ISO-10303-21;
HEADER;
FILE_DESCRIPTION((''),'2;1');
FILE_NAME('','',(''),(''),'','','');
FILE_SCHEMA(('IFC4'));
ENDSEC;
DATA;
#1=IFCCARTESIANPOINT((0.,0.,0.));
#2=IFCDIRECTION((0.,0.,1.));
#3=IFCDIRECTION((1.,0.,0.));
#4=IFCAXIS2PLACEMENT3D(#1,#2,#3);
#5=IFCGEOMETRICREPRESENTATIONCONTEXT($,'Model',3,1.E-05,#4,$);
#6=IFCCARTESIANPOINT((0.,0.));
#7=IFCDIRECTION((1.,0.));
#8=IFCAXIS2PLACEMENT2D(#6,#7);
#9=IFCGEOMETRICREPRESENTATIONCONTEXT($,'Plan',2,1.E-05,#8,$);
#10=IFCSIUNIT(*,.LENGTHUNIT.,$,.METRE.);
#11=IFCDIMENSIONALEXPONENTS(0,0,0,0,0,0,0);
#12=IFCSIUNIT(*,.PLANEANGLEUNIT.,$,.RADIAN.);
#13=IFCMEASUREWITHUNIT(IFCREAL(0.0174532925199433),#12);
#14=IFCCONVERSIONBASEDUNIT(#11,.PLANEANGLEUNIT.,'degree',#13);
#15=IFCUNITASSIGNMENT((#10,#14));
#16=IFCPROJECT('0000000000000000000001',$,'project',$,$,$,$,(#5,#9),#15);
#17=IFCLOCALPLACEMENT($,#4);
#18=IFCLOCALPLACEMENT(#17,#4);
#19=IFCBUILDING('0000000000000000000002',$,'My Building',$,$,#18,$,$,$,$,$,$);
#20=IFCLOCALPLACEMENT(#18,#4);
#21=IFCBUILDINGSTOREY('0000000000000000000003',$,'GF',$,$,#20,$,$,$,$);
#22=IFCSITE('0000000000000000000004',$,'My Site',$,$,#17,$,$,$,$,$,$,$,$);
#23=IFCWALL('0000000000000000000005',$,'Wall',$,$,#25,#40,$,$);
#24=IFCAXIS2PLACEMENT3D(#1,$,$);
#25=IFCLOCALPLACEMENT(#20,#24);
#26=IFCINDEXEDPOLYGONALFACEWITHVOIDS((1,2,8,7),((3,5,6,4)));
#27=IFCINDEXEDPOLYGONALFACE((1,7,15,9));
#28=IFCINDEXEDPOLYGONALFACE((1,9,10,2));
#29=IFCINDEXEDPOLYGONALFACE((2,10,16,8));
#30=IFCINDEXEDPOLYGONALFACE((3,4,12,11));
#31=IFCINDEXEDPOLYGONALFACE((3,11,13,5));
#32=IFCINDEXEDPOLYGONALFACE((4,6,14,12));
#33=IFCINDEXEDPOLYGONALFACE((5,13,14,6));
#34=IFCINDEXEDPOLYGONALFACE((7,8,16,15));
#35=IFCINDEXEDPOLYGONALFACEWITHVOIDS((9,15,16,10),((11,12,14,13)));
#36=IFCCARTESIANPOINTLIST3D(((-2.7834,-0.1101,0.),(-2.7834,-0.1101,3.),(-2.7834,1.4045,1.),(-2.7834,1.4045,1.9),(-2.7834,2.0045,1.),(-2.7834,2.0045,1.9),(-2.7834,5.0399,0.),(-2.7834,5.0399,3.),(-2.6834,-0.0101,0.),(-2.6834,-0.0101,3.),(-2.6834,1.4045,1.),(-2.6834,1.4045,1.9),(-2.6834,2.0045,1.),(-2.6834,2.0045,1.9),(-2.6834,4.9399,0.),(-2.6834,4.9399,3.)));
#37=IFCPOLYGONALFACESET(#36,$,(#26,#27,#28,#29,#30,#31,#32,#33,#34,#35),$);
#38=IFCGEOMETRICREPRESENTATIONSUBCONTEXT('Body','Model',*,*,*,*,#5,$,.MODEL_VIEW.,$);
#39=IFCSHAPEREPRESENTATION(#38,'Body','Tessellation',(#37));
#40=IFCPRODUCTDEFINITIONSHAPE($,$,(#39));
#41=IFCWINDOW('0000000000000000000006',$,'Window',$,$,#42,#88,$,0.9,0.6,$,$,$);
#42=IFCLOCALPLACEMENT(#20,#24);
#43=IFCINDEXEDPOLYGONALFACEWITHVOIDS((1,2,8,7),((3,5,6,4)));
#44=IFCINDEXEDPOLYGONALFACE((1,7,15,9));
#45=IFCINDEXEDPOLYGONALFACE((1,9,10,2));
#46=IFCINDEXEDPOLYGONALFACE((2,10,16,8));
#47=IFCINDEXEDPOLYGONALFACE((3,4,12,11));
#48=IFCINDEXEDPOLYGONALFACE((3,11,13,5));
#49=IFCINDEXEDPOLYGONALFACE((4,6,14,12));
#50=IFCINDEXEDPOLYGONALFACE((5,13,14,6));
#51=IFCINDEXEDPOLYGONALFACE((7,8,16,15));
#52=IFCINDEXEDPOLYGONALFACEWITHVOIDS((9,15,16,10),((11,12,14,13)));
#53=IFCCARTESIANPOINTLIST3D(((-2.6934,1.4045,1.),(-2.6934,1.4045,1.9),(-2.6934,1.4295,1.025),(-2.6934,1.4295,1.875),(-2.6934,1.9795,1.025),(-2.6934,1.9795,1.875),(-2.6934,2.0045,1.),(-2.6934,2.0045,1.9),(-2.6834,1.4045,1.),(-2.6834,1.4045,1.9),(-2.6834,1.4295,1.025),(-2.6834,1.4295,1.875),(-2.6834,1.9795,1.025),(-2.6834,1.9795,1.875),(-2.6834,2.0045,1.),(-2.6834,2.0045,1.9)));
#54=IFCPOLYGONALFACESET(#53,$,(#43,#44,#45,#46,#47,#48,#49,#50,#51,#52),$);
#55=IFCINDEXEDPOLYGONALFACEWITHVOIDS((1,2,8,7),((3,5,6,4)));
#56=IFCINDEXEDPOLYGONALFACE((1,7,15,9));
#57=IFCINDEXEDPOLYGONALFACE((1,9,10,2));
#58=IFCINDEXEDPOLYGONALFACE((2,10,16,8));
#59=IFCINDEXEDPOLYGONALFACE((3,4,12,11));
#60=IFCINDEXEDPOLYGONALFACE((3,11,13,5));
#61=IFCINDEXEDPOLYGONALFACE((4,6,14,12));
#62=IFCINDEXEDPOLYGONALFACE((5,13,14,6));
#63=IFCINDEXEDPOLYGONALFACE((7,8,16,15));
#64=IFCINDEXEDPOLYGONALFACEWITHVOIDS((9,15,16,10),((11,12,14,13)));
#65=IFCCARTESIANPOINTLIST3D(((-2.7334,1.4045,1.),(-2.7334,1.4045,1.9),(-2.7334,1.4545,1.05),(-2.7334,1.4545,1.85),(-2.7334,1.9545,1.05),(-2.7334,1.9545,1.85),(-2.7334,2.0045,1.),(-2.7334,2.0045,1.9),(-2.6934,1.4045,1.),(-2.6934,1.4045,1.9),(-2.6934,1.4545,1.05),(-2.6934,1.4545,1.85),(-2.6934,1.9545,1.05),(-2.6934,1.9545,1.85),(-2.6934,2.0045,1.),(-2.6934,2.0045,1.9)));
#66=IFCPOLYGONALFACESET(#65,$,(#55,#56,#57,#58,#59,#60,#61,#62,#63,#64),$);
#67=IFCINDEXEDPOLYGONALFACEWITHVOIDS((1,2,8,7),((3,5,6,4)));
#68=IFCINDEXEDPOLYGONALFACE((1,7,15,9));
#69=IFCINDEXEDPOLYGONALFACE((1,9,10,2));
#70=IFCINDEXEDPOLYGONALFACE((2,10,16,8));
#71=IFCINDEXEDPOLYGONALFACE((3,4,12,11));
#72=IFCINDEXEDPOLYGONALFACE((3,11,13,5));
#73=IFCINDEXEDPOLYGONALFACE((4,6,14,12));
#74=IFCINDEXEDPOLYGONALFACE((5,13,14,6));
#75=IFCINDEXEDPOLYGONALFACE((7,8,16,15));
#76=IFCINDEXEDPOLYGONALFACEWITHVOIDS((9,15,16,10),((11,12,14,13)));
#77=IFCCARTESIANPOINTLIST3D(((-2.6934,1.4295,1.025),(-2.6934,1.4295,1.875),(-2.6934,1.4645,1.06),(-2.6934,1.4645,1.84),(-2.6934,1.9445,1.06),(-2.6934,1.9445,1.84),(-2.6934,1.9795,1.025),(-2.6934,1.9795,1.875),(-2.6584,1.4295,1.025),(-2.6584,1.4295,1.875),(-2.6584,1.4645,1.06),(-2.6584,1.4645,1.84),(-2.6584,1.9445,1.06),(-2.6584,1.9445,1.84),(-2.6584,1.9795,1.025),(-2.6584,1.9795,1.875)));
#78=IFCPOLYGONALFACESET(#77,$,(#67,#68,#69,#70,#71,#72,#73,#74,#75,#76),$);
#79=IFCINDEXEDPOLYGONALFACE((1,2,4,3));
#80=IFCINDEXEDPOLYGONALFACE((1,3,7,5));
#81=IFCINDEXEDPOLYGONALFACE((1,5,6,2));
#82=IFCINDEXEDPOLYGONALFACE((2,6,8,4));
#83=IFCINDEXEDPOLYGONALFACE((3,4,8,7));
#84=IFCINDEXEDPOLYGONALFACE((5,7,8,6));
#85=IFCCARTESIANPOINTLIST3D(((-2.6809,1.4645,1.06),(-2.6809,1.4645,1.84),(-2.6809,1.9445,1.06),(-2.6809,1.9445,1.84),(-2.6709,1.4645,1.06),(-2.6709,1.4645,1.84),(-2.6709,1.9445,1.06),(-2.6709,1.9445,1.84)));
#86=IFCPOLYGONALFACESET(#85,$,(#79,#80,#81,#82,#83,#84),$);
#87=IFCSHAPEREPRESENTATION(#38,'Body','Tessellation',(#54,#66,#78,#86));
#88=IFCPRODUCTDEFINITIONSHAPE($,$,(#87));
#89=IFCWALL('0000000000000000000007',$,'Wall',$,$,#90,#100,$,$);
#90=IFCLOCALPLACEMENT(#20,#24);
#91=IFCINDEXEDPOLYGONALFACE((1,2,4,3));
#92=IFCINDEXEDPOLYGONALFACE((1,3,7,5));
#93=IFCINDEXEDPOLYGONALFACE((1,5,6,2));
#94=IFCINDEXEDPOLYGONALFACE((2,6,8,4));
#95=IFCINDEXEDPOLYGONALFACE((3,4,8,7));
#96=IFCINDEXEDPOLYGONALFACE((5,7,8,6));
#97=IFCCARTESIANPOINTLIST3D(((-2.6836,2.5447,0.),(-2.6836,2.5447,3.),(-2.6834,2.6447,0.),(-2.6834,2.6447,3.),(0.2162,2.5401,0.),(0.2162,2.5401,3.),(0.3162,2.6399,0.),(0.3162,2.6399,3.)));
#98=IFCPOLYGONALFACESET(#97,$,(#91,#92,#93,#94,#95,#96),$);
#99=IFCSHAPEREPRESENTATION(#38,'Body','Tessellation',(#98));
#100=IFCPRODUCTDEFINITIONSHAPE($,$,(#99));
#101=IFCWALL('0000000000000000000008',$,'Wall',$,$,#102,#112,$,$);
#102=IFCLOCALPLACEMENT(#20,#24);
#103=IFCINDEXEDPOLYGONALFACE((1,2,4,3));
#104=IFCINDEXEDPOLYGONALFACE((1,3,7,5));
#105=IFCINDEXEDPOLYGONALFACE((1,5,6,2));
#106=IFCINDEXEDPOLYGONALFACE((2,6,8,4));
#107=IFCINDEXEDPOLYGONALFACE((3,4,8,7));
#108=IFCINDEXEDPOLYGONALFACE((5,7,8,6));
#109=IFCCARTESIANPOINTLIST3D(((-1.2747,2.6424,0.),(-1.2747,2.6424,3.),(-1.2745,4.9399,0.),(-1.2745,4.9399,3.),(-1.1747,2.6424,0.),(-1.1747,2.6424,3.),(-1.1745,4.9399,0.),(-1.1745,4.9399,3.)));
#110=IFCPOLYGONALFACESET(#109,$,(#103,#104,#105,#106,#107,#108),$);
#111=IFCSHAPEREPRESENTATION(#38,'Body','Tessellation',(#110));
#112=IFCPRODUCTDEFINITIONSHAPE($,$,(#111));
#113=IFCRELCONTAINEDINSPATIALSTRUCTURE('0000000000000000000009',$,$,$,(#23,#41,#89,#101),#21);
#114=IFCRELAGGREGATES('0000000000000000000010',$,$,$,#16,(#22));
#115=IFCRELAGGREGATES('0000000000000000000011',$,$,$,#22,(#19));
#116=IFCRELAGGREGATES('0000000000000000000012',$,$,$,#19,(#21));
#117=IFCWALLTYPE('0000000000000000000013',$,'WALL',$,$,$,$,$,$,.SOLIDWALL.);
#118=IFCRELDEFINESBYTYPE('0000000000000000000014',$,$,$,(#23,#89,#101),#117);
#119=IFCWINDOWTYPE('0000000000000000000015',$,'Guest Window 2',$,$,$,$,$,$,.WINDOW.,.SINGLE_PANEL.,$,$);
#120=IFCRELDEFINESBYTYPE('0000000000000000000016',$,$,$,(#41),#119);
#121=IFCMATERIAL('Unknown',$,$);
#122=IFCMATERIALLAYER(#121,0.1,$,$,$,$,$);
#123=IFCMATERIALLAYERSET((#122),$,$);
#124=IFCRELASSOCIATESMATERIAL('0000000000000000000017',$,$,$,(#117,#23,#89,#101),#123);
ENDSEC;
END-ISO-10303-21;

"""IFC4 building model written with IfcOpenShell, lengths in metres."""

from ifc_helpers import new_model, entity, si_unit, converted_unit, frame, origin_with_axes, origin_2d_with_axis, place, context, subcontext, project, spatial, line, indexed_curve, outline, extrude, shape, source, transform, mapped, material, layer, layer_set, layer_usage, type_object, type_shapes, element, fill, save


model = new_model("IFC4")

# Units and contexts
model_context = context("Model", 3, precision=1e-05, world=origin_with_axes())
plan_context = context("Plan", 2, precision=1e-05, world=origin_2d_with_axis())
body_context_1 = subcontext(model_context, "Body", "Model", "MODEL_VIEW")
body_context_2 = subcontext(plan_context, "Body", "Plan", "PLAN_VIEW")
ifc_project = project(units=[si_unit("LENGTHUNIT", "METRE"), converted_unit("PLANEANGLEUNIT", "degree", entity("IfcReal", 0.0174532925199433), si_unit("PLANEANGLEUNIT", "RADIAN"), dimensions=[0, 0, 0, 0, 0, 0, 0])], contexts=[model_context, plan_context])

# Site, building, storey
site_placement = place(None, origin_with_axes())
site = spatial("IfcSite", under=ifc_project, at=site_placement, Name="My Site")
building_placement = place(site_placement, origin_with_axes())
building = spatial("IfcBuilding", under=site, at=building_placement, Name="My Building")
storey_placement = place(building_placement, origin_with_axes())
storey = spatial("IfcBuildingStorey", under=building, at=storey_placement, Name="GF")

# Shared definitions
ifc_material = material(Name="Unknown")

# Shared definitions
ifc_layer = layer(ifc_material, 0.1)
ifc_layer_set = layer_set([ifc_layer])
wall_type = type_object("IfcWallType", Name="WALL", PredefinedType="SOLIDWALL", material=ifc_layer_set)

# Wall, opening, window
ifc_layer_usage_1 = layer_usage(ifc_layer_set, "AXIS2", "POSITIVE", 0.0)
wall_1_placement = place(storey_placement, frame((-2.7834, 5.0399, 0.0), z_axis=(0.0, 0.0, 1.0), x_axis=(0.0, -1.0, 0.0)))
wall_1 = element("IfcWall", 1, at=wall_1_placement, inside=storey, type_object=wall_type, material=ifc_layer_usage_1, Name="Wall", context=body_context_1, shape_type="SweptSolid", body=[
    extrude(outline(indexed_curve([(0.0, 0.0), (0.1, 0.1), (5.05, 0.1), (5.15, 0.0)], segments=[line(1, 2, 3, 4, 1)])), origin_with_axes(), (0.0, 0.0, 1.0), 3.0),
])
shared_shape_1 = source(origin_with_axes(), body_context_1, "Body", "SweptSolid", [
    extrude(outline(indexed_curve([(0.0, 0.0), (0.6, 0.0), (0.6, 0.9), (0.0, 0.9)], segments=[line(1, 2, 3, 4, 1)])), frame((0.0, -0.6, 0.0), z_axis=(0.0, -1.0, 0.0), x_axis=(1.0, 0.0, 0.0)), (0.0, 0.0, -1.0), 1.2),
])
opening_1_placement = place(wall_1_placement, frame((3.0354, 0.0, 1.0), z_axis=(0.0, 0.0, 1.0), x_axis=(1.0, 0.0, 0.0)))
opening_1 = element("IfcOpeningElement", 2, at=opening_1_placement, cuts=wall_1, PredefinedType="OPENING", context=body_context_1, shape_type="MappedRepresentation", body=[
    mapped(shared_shape_1, transform((0.0, 0.0, 0.0), x_axis=(1.0, 0.0, 0.0), y_axis=(0.0, 1.0, 0.0), z_axis=(0.0, 0.0, 1.0), scale=1.0)),
])
window_type_1 = type_object("IfcWindowType", Name="Guest Window 2", PartitioningType="SINGLE_PANEL", PredefinedType="WINDOW")
shared_shape_2 = source(origin_with_axes(), body_context_1, "Body", "SweptSolid", [
    extrude(outline(indexed_curve([(0.0, 0.0), (0.6, 0.0), (0.6, 0.9), (0.0, 0.9)], segments=[line(1, 2, 3, 4, 1)]), holes=[indexed_curve([(0.025, 0.025), (0.575, 0.025), (0.575, 0.875), (0.025, 0.875)], segments=[line(1, 2, 3, 4, 1)])]), frame((0.0, 0.09, 0.0), z_axis=(0.0, -1.0, 0.0), x_axis=(1.0, 0.0, 0.0)), (0.0, 0.0, -1.0), 0.01),
    extrude(outline(indexed_curve([(0.0, 0.0), (0.6, 0.0), (0.6, 0.9), (0.0, 0.9)], segments=[line(1, 2, 3, 4, 1)]), holes=[indexed_curve([(0.05, 0.05), (0.55, 0.05), (0.55, 0.85), (0.05, 0.85)], segments=[line(1, 2, 3, 4, 1)])]), frame((0.0, 0.05, 0.0), z_axis=(0.0, -1.0, 0.0), x_axis=(1.0, 0.0, 0.0)), (0.0, 0.0, -1.0), 0.04),
    extrude(outline(indexed_curve([(0.0, 0.0), (0.55, 0.0), (0.55, 0.85), (0.0, 0.85)], segments=[line(1, 2, 3, 4, 1)]), holes=[indexed_curve([(0.035, 0.035), (0.515, 0.035), (0.515, 0.815), (0.035, 0.815)], segments=[line(1, 2, 3, 4, 1)])]), frame((0.025, 0.09, 0.025), z_axis=(0.0, -1.0, 0.0), x_axis=(1.0, 0.0, 0.0)), (0.0, 0.0, -1.0), 0.035),
    extrude(outline(indexed_curve([(0.035, 0.035), (0.515, 0.035), (0.515, 0.815), (0.035, 0.815)], segments=[line(1, 2, 3, 4, 1)])), frame((0.025, 0.1025, 0.025), z_axis=(0.0, -1.0, 0.0), x_axis=(1.0, 0.0, 0.0)), (0.0, 0.0, -1.0), 0.01),
])
shared_shape_3 = source(origin_with_axes(), body_context_2, "Body", "Curve2D", [
    entity("IfcIndexedPolyCurve", entity("IfcCartesianPointList2D", [[0.05, 0.05], [0.55, 0.05]])),
    entity("IfcIndexedPolyCurve", entity("IfcCartesianPointList2D", [[0.0, 0.1], [0.025, 0.1], [0.025, 0.09], [0.05, 0.09], [0.05, 0.05], [0.0, 0.05]]), [entity("IfcLineIndex", [1, 2, 3, 4, 5, 6, 1])]),
    entity("IfcIndexedPolyCurve", entity("IfcCartesianPointList2D", [[0.6, 0.1], [0.575, 0.1], [0.575, 0.09], [0.55, 0.09], [0.55, 0.05], [0.6, 0.05]]), [entity("IfcLineIndex", [1, 2, 3, 4, 5, 6, 1])]),
    entity("IfcIndexedPolyCurve", entity("IfcCartesianPointList2D", [[0.025, 0.09], [0.06, 0.09], [0.06, 0.125], [0.025, 0.125]]), [entity("IfcLineIndex", [1, 2, 3, 4, 1])]),
    entity("IfcIndexedPolyCurve", entity("IfcCartesianPointList2D", [[0.575, 0.09], [0.54, 0.09], [0.54, 0.125], [0.575, 0.125]]), [entity("IfcLineIndex", [1, 2, 3, 4, 1])]),
    entity("IfcIndexedPolyCurve", entity("IfcCartesianPointList2D", [[0.06, 0.09], [0.54, 0.09]])),
    entity("IfcIndexedPolyCurve", entity("IfcCartesianPointList2D", [[0.06, 0.125], [0.54, 0.125]])),
    entity("IfcIndexedPolyCurve", entity("IfcCartesianPointList2D", [[0.06, 0.1075], [0.54, 0.1075]])),
])
type_shapes(window_type_1, [shared_shape_2, shared_shape_3])
window_1_placement = place(opening_1_placement, frame((0.0, 0.0, 0.0), z_axis=(0.0, 0.0, 1.0), x_axis=(1.0, 0.0, 0.0)))
window_1 = element("IfcWindow", 3, at=window_1_placement, inside=storey, type_object=window_type_1, Name="Window", OverallHeight=0.9, OverallWidth=0.6, shapes=[
    shape(body_context_1, "Body", "MappedRepresentation", [mapped(shared_shape_2, transform((0.0, 0.0, 0.0), x_axis=(1.0, 0.0, 0.0), y_axis=(0.0, 1.0, 0.0), z_axis=(0.0, 0.0, 1.0), scale=1.0))]),
    shape(body_context_2, "Body", "MappedRepresentation", [mapped(shared_shape_3, transform((0.0, 0.0, 0.0), x_axis=(1.0, 0.0, 0.0), y_axis=(0.0, 1.0, 0.0), z_axis=(0.0, 0.0, 1.0), scale=1.0))]),
])
fill(opening_1, window_1)

# Walls
ifc_layer_usage_2 = layer_usage(ifc_layer_set, "AXIS2", "POSITIVE", 0.0)
wall_2_placement = place(storey_placement, frame((0.3162, 2.6399, 0.0), z_axis=(0.0, 0.0, 1.0), x_axis=(-0.999999, 0.001594, 0.0)))
element("IfcWall", 4, at=wall_2_placement, inside=storey, type_object=wall_type, material=ifc_layer_usage_2, Name="Wall", context=body_context_1, shape_type="SweptSolid", body=[
    extrude(outline(indexed_curve([(0.0, 0.0), (0.0998, 0.1), (2.9996, 0.1), (2.9996, 0.0)], segments=[line(1, 2, 3, 4, 1)])), origin_with_axes(), (0.0, 0.0, 1.0), 3.0),
])
ifc_layer_usage_3 = layer_usage(ifc_layer_set, "AXIS2", "POSITIVE", 0.0)
wall_3_placement = place(storey_placement, frame((-1.2745, 4.9399, 0.0), z_axis=(0.0, 0.0, 1.0), x_axis=(-0.000123, -1.0, 0.0)))
element("IfcWall", 5, at=wall_3_placement, inside=storey, type_object=wall_type, material=ifc_layer_usage_3, Name="Wall", context=body_context_1, shape_type="SweptSolid", body=[
    extrude(outline(indexed_curve([(0.0, 0.0), (0.0, 0.1), (2.2975, 0.1), (2.2975, 0.0)], segments=[line(1, 2, 3, 4, 1)])), origin_with_axes(), (0.0, 0.0, 1.0), 3.0),
])

save(model, "model.ifc")
